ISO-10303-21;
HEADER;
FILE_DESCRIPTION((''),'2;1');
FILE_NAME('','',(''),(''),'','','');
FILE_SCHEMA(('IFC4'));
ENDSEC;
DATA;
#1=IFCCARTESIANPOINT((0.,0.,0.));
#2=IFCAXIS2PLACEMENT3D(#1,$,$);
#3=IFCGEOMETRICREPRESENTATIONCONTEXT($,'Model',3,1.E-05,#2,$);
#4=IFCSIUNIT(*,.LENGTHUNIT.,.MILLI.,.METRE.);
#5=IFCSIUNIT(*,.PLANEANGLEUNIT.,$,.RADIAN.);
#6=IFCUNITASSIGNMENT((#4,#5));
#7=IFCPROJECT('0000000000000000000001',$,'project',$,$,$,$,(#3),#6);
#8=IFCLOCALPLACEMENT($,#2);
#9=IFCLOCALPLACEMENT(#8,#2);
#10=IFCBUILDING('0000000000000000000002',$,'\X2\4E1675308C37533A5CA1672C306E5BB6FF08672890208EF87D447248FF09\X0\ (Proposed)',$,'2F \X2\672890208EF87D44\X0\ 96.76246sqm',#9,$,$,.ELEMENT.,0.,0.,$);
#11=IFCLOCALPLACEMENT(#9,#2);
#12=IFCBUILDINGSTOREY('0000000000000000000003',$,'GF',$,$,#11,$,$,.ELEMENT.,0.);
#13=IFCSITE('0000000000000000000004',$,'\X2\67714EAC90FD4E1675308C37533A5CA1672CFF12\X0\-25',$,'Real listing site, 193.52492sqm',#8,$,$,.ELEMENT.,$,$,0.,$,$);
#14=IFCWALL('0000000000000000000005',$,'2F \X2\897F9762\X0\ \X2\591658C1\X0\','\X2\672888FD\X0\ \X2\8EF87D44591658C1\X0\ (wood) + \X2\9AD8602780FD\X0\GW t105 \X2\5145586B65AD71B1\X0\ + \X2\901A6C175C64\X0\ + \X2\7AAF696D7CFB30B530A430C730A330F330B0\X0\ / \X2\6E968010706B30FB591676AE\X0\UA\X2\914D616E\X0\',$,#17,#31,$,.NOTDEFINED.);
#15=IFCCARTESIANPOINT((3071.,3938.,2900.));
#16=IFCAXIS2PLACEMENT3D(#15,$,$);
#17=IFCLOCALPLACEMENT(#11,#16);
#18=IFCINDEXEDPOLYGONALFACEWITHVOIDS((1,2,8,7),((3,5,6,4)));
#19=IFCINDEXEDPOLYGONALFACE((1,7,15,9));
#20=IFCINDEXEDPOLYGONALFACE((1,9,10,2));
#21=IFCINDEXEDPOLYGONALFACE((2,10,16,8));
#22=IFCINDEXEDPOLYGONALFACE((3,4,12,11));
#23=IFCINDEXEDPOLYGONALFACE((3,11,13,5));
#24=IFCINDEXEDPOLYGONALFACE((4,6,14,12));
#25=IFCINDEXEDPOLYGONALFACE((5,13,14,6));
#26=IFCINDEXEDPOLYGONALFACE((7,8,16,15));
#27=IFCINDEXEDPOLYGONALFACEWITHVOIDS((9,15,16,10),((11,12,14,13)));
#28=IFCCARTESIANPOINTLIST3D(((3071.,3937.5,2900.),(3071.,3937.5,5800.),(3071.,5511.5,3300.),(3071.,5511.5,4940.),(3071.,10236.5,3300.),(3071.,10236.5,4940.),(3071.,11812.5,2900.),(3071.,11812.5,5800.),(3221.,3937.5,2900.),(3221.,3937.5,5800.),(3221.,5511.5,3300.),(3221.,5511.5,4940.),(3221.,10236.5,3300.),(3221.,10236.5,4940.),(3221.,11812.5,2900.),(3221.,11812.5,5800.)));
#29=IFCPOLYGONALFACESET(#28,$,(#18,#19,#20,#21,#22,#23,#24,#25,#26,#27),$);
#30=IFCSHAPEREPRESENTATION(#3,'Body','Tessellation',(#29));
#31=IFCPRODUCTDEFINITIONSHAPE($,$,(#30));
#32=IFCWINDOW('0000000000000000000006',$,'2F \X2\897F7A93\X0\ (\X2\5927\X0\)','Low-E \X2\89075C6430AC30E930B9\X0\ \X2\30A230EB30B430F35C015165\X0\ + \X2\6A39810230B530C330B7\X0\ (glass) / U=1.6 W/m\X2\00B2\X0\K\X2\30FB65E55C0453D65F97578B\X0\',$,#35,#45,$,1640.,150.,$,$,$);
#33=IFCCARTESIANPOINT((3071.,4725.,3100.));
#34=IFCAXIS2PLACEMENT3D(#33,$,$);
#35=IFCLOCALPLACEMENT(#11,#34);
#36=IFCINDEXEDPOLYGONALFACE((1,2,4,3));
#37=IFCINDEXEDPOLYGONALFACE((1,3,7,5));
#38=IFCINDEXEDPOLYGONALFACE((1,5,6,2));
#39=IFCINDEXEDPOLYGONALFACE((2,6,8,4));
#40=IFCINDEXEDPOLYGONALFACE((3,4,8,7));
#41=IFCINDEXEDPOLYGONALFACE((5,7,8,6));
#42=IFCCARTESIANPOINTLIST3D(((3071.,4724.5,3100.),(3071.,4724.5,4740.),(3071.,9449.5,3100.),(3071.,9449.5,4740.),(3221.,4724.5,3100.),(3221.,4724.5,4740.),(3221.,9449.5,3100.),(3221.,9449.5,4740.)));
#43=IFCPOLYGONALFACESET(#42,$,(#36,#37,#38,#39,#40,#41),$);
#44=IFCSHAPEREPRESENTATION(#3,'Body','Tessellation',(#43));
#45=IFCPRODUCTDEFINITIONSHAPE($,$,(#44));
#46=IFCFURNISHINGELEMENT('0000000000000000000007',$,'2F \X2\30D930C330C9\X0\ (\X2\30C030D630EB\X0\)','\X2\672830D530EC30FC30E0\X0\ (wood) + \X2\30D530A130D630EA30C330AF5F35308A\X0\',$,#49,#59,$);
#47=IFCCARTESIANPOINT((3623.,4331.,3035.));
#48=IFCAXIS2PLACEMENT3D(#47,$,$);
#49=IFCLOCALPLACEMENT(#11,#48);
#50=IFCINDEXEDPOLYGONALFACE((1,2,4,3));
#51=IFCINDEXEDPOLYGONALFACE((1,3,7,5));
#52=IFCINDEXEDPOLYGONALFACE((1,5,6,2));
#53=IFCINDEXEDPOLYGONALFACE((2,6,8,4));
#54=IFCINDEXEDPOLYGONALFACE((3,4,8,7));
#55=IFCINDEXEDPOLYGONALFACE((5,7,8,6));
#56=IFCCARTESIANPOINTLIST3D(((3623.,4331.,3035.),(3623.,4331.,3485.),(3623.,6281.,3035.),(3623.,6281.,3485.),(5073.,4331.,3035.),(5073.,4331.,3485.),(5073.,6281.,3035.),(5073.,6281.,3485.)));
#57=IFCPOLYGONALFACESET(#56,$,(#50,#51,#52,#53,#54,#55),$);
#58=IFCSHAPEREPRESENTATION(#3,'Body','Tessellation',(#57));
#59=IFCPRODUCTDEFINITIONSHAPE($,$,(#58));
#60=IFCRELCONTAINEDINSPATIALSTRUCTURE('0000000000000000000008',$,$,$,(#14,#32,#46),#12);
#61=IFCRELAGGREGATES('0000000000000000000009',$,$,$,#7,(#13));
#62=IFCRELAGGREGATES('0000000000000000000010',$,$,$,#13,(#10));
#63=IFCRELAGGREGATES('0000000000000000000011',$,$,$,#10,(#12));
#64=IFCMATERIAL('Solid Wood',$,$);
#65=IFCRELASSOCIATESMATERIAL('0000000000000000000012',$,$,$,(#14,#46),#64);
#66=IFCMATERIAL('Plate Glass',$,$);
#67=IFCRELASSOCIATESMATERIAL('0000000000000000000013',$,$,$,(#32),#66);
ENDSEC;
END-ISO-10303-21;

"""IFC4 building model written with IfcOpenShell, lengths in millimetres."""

from ifc_helpers import new_model, si_unit, frame, frame_2d, origin, place, context, project, spatial, rectangle, extrude, material, element, fill, save


model = new_model("IFC4")

# Units and contexts
model_context = context("Model", 3, precision=1e-05, world=origin())
ifc_project = project(units=[si_unit("LENGTHUNIT", "METRE", prefix="MILLI"), si_unit("PLANEANGLEUNIT", "RADIAN")], contexts=[model_context])

# Site, building, storey
site_placement = place(None, origin())
site = spatial("IfcSite", under=ifc_project, at=site_placement, Name="東京都世田谷区岡本２-25", ObjectType="Real listing site, 193.52492sqm", CompositionType="ELEMENT", RefElevation=0.0)
building_placement = place(site_placement, origin())
building = spatial("IfcBuilding", under=site, at=building_placement, Name="世田谷区岡本の家（木造軸組版） (Proposed)", ObjectType="2F 木造軸組 96.76246sqm", CompositionType="ELEMENT", ElevationOfRefHeight=0.0, ElevationOfTerrain=0.0)
storey_placement = place(building_placement, origin())
storey = spatial("IfcBuildingStorey", under=building, at=storey_placement, Name="GF", CompositionType="ELEMENT", Elevation=0.0)

# Shared definitions
ifc_material_1 = material(Name="Solid Wood")

# Shared definitions
ifc_material_2 = material(Name="Plate Glass")

# Wall, opening, window
wall_1_placement = place(storey_placement, frame((3071.0, 3938.0, 2900.0)))
wall_1 = element("IfcWall", 1, at=wall_1_placement, inside=storey, material=ifc_material_1, Name="2F 西面 外壁", Description="木製 軸組外壁 (wood) + 高性能GW t105 充填断熱 + 通気層 + 窯業系サイディング / 準耐火・外皮UA配慮", PredefinedType="NOTDEFINED", context=model_context, shape_type="SweptSolid", body=[
    extrude(rectangle(XDim=150.0, YDim=7875.0, at=frame_2d((75.0, 3937.0))), frame((3071.0, 3938.0, 2900.0)), (0.0, 0.0, 1.0), 2900.0),
])
opening_1_placement = place(storey_placement, frame((3071.0, 4725.0, 3100.0)))
opening_1 = element("IfcOpeningElement", 2, at=opening_1_placement, cuts=wall_1, PredefinedType="NOTDEFINED", context=model_context, shape_type="SweptSolid", body=[
    extrude(rectangle(XDim=150.0, YDim=4725.0, at=frame_2d((75.0, 2362.0))), frame((3071.0, 4725.0, 3100.0)), (0.0, 0.0, 1.0), 1640.0),
])
window_1_placement = place(storey_placement, frame((3071.0, 4725.0, 3100.0)))
window_1 = element("IfcWindow", 3, at=window_1_placement, inside=storey, material=ifc_material_2, Name="2F 西窓 (大)", Description="Low-E 複層ガラス アルゴン封入 + 樹脂サッシ (glass) / U=1.6 W/m²K・日射取得型", OverallHeight=1640.0, OverallWidth=150.0, context=model_context, shape_type="SweptSolid", body=[
    extrude(rectangle(XDim=150.0, YDim=4725.0, at=frame_2d((75.0, 2362.0))), frame((3071.0, 4725.0, 3100.0)), (0.0, 0.0, 1.0), 1640.0),
])
fill(opening_1, window_1)

# Furnishing element
furnishing_placement = place(storey_placement, frame((3623.0, 4331.0, 3035.0)))
element("IfcFurnishingElement", 4, at=furnishing_placement, inside=storey, material=ifc_material_1, Name="2F ベッド (ダブル)", Description="木フレーム (wood) + ファブリック張り", context=model_context, shape_type="SweptSolid", body=[
    extrude(rectangle(XDim=1450.0, YDim=1950.0, at=frame_2d((725.0, 975.0))), frame((3623.0, 4331.0, 3035.0)), (0.0, 0.0, 1.0), 450.0),
])

save(model, "model.ifc")
